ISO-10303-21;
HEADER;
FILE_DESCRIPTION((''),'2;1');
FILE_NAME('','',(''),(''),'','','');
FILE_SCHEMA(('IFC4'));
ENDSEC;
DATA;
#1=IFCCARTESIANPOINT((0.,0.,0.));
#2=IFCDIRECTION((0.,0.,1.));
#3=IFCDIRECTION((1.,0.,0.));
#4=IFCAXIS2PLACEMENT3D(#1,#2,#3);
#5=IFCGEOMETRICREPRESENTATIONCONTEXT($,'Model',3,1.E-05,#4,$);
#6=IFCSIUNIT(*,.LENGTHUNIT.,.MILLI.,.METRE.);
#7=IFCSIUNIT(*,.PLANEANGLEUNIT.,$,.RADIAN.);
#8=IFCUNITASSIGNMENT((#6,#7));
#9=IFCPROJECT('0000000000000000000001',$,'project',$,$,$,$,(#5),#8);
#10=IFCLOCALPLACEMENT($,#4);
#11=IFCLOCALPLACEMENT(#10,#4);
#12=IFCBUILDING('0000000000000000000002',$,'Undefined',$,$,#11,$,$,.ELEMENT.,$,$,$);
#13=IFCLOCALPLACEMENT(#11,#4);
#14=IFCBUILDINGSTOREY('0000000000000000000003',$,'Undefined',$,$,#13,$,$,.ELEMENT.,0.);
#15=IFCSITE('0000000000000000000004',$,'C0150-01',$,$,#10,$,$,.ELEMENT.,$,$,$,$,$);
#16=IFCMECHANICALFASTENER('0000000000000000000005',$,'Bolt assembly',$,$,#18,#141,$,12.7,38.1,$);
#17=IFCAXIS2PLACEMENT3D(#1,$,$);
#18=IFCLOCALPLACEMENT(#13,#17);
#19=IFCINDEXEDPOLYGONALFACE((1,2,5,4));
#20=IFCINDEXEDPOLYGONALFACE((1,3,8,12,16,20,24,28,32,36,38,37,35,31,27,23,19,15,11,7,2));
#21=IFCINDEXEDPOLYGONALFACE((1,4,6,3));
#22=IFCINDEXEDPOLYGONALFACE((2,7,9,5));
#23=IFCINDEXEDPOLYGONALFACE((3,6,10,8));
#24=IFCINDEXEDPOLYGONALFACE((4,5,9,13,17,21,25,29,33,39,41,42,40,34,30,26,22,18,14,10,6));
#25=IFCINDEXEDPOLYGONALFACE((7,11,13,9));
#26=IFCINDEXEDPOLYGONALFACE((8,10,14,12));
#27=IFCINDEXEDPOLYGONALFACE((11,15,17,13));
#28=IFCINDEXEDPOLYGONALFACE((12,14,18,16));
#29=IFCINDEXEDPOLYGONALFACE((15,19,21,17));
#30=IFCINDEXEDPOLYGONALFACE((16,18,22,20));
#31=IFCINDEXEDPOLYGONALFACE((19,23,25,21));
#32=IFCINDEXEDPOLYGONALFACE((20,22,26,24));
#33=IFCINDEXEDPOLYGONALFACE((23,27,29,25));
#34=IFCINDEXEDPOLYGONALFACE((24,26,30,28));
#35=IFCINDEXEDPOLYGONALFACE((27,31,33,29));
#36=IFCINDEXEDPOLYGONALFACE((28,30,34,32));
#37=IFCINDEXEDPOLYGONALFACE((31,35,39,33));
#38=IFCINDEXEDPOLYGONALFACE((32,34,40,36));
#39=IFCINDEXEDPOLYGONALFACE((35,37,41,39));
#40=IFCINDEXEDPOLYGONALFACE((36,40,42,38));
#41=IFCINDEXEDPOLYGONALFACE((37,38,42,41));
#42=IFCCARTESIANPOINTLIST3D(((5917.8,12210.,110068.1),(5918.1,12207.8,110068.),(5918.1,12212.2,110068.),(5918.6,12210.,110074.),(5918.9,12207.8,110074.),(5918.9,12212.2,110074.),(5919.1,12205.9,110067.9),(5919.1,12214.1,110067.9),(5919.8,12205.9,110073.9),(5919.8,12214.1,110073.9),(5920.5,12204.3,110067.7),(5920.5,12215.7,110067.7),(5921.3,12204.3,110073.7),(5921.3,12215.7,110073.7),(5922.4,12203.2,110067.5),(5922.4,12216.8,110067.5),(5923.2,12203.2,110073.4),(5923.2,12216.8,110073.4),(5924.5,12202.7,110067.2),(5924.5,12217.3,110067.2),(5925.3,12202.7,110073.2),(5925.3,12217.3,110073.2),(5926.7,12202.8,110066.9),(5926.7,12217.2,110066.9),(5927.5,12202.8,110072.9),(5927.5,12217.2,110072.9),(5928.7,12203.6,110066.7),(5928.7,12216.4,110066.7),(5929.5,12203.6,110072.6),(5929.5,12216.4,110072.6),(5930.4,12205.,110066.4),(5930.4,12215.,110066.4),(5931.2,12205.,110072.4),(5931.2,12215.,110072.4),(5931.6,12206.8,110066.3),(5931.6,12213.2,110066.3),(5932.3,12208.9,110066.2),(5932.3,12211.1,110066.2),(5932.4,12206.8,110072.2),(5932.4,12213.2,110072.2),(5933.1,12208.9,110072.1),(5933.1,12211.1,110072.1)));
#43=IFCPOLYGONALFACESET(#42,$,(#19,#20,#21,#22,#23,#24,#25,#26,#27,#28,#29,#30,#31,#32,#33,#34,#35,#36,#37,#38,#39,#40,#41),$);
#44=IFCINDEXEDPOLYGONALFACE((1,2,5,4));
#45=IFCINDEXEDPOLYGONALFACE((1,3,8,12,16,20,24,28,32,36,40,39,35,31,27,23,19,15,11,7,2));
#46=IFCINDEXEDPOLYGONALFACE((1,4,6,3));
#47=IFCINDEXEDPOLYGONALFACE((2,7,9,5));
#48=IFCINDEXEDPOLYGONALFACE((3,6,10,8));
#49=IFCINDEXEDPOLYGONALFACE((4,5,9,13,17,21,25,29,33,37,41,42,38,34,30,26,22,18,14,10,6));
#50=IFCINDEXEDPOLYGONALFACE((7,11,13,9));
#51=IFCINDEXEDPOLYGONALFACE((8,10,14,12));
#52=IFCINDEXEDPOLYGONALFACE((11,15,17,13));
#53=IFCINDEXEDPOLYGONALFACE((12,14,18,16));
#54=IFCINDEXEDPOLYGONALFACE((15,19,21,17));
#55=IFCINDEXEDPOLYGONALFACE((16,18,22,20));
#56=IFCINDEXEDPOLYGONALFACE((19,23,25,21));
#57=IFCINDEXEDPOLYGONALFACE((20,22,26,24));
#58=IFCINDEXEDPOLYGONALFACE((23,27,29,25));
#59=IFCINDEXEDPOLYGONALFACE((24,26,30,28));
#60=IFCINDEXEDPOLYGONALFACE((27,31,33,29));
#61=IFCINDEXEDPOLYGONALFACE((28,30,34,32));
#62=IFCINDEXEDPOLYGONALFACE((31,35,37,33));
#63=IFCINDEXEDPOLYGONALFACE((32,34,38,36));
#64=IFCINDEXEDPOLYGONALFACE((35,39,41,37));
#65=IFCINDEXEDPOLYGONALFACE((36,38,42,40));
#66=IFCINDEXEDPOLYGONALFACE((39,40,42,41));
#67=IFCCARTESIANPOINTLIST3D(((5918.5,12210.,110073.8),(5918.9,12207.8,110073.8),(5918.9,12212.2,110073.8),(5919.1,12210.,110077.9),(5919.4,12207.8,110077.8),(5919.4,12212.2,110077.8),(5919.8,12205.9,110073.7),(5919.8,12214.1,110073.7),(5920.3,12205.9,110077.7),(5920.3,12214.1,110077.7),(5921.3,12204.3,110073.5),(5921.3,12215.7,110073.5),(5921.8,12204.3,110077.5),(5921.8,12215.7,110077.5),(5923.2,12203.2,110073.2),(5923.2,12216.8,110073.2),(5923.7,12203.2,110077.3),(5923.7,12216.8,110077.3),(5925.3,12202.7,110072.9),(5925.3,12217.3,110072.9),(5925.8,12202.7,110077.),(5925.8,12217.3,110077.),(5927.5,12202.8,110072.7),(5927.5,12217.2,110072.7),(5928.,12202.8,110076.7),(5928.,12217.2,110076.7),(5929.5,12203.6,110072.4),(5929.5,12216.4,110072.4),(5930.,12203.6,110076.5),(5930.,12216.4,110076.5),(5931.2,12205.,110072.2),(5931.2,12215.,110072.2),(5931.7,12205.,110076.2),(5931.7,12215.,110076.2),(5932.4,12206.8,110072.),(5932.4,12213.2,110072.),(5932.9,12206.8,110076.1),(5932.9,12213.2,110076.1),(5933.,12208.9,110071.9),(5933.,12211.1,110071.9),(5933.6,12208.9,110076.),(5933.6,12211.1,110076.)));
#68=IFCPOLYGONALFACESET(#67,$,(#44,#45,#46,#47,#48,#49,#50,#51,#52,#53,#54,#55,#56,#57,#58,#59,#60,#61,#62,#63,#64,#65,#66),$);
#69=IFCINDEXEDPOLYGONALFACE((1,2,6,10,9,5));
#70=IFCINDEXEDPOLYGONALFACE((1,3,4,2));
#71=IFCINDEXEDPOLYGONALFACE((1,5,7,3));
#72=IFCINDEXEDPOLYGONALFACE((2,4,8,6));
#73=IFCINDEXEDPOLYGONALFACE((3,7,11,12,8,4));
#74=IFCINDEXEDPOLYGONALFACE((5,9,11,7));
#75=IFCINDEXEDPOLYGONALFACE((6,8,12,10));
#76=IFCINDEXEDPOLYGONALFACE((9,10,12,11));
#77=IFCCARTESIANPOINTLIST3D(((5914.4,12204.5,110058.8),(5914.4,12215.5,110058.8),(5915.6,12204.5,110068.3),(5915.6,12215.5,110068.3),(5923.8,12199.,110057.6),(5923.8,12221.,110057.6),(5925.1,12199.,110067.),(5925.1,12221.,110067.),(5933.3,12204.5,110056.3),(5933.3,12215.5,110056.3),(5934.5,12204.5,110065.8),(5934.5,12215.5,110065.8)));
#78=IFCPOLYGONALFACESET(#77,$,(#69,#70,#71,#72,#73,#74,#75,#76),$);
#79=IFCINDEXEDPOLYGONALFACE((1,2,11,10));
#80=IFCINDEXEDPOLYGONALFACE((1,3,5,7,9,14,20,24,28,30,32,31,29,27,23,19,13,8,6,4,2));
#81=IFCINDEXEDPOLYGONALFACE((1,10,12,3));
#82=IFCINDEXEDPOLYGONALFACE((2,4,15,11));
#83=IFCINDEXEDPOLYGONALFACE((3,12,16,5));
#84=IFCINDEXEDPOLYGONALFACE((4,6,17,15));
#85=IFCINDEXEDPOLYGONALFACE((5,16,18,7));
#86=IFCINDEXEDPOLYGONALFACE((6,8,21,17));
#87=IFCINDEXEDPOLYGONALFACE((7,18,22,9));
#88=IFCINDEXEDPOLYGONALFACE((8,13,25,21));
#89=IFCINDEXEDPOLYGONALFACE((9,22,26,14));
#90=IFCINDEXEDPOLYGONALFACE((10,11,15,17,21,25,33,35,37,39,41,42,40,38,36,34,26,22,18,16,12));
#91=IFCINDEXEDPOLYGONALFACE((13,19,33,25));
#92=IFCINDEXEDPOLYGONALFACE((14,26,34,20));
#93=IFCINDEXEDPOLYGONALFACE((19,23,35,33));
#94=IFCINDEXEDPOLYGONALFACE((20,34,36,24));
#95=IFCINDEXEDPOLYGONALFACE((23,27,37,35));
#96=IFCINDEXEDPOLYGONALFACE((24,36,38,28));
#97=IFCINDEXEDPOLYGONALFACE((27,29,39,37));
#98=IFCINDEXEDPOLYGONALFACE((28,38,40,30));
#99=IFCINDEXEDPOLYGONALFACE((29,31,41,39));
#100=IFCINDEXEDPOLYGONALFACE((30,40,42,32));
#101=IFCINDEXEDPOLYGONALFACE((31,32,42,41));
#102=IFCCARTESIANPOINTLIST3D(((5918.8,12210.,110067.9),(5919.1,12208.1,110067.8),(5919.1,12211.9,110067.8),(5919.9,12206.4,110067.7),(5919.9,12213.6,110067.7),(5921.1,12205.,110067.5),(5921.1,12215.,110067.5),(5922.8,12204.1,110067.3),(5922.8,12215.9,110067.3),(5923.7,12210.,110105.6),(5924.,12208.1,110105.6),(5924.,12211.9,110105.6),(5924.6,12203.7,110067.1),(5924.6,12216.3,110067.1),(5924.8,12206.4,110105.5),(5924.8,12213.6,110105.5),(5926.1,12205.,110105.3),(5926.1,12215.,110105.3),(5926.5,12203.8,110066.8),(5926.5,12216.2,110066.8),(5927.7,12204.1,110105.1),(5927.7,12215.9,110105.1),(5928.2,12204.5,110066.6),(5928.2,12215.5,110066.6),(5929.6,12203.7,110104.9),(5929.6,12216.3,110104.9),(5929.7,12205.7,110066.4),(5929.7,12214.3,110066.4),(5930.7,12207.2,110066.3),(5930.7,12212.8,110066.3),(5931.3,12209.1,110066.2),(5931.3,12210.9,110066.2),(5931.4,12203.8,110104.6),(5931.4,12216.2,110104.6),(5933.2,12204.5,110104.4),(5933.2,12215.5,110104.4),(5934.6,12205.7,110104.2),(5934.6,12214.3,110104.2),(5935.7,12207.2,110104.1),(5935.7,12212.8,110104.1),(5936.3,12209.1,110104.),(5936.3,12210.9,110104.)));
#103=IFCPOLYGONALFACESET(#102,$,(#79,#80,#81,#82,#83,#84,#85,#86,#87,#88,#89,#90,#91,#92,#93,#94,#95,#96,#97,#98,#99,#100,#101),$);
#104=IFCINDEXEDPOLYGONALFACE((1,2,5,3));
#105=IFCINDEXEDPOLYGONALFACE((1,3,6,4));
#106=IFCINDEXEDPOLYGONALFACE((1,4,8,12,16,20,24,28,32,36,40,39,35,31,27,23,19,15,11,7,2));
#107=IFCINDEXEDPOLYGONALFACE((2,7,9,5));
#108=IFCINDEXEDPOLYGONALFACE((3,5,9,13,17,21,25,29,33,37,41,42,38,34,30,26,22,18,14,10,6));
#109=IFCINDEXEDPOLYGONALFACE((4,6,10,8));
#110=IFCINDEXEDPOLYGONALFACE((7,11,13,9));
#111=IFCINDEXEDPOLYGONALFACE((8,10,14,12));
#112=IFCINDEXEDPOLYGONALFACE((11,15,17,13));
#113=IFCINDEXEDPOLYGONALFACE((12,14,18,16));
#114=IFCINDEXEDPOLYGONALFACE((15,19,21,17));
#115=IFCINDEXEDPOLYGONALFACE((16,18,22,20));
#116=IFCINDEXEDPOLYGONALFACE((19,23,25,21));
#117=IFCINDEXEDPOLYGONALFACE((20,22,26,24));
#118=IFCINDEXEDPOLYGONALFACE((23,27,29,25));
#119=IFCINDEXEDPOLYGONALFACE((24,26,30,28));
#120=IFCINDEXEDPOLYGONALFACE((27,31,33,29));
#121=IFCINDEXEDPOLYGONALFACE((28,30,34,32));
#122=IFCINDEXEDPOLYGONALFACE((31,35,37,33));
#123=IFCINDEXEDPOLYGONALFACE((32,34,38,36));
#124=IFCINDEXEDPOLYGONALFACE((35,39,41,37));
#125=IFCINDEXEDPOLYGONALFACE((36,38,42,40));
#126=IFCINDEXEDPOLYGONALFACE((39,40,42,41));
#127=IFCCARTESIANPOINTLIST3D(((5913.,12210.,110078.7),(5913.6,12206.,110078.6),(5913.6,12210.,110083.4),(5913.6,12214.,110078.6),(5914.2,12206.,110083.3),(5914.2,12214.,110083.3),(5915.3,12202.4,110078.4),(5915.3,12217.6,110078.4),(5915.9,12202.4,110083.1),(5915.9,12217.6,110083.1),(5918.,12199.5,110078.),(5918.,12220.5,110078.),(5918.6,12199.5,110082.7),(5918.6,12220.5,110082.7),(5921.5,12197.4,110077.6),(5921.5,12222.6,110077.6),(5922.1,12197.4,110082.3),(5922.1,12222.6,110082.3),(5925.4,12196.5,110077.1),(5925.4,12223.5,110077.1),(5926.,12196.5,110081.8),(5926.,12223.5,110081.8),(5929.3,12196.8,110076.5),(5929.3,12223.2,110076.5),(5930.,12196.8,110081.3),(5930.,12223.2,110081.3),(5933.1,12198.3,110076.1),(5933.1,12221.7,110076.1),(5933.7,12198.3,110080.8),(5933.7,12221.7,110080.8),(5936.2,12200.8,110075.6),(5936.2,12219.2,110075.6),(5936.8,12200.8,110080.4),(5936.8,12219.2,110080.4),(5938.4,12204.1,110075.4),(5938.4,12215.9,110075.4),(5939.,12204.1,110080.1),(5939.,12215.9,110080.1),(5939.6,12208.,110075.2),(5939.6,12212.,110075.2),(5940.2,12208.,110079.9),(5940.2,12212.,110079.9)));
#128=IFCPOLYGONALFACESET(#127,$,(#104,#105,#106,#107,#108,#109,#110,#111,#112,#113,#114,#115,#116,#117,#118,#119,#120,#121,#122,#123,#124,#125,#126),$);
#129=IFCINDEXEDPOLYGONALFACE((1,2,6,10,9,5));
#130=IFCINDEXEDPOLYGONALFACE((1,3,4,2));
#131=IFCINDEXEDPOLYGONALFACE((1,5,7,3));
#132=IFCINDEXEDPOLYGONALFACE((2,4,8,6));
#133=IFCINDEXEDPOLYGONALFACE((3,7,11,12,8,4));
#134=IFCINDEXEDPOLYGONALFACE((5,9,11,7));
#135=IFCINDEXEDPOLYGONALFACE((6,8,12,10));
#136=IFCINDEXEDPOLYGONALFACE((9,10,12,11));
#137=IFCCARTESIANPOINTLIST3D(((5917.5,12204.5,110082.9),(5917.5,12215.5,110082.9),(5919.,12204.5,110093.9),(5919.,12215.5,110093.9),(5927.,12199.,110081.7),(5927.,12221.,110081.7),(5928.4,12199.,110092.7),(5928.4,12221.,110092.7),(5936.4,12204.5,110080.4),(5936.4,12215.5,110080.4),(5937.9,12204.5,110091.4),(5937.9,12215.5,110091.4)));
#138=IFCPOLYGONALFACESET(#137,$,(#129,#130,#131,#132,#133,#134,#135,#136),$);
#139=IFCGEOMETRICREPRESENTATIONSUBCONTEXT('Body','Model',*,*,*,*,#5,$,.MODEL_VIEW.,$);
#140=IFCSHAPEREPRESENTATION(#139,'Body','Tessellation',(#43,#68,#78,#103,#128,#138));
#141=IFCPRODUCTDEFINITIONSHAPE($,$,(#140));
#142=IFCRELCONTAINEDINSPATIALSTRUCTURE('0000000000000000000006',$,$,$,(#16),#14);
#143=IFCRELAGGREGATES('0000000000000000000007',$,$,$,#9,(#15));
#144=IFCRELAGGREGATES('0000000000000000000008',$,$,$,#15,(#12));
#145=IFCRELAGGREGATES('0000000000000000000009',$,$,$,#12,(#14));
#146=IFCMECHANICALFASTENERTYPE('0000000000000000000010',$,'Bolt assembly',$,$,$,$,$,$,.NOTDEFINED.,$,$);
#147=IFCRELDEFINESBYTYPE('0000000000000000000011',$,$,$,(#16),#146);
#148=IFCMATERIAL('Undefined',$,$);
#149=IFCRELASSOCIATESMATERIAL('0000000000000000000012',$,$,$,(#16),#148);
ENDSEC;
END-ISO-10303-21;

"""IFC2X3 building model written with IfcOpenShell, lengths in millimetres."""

from ifc_helpers import new_model, si_unit, frame, origin_with_axes, origin_2d_with_axis, place, context, subcontext, project, spatial, polyline, circle, outline, extrude, source, transform, mapped, material, type_object, element, save


model = new_model("IFC2X3")

# Units and contexts
model_context = context("Model", 3, precision=1e-05, world=origin_with_axes())
body_context = subcontext(model_context, "Body", "Model", "MODEL_VIEW")
ifc_project = project(units=[si_unit("LENGTHUNIT", "METRE", prefix="MILLI"), si_unit("PLANEANGLEUNIT", "RADIAN")], contexts=[model_context])

# Site, building, storey
site_placement = place(None, origin_with_axes())
site = spatial("IfcSite", under=ifc_project, at=site_placement, Name="C0150-01", CompositionType="ELEMENT")
building_placement = place(site_placement, origin_with_axes())
building = spatial("IfcBuilding", under=site, at=building_placement, Name="Undefined", CompositionType="ELEMENT")
storey_placement = place(building_placement, origin_with_axes())
storey = spatial("IfcBuildingStorey", under=building, at=storey_placement, Name="Undefined", CompositionType="ELEMENT", Elevation=0.0)

# Mechanical fastener
ifc_material_1 = material(Name="Undefined")
mechanical_fastener_type = type_object("IfcMechanicalFastenerType", Name="Bolt assembly")
shared_shape_1 = source(origin_with_axes(), body_context, "Body", "SweptSolid", [
    extrude(circle(Radius=7.3, at=origin_2d_with_axis()), frame((0.0, -9.9, 0.0), z_axis=(0.0, 1.0, 0.0), x_axis=(1.0, 0.0, 0.0)), (0.0, 0.0, 1.0), 6.0),
    extrude(circle(Radius=7.3, at=origin_2d_with_axis()), frame((0.0, -4.1, 0.0), z_axis=(0.0, 1.0, 0.0), x_axis=(1.0, 0.0, 0.0)), (0.0, 0.0, 1.0), 4.1),
    extrude(outline(polyline([(9.5, -5.5), (9.5, 5.5), (0.0, 11.0), (-9.5, 5.5), (-9.5, -5.5), (0.0, -11.0), (9.5, -5.5)])), frame((0.0, -19.5, 0.0), z_axis=(0.0, 1.0, 0.0), x_axis=(1.0, 0.0, 0.0)), (0.0, 0.0, 1.0), 9.5),
    extrude(circle(Radius=6.3, at=origin_2d_with_axis()), frame((0.0, -10.0, 0.0), z_axis=(0.0, 1.0, 0.0), x_axis=(1.0, 0.0, 0.0)), (0.0, 0.0, 1.0), 38.1),
    extrude(circle(Radius=13.5, at=origin_2d_with_axis()), frame((0.0, 0.0, 0.0), z_axis=(0.0, 1.0, 0.0), x_axis=(1.0, 0.0, 0.0)), (0.0, 0.0, 1.0), 4.8),
    extrude(outline(polyline([(9.5, -5.5), (9.5, 5.5), (0.0, 11.0), (-9.5, 5.5), (-9.5, -5.5), (0.0, -11.0), (9.5, -5.5)])), frame((0.0, 4.8, 0.0), z_axis=(0.0, 1.0, 0.0), x_axis=(1.0, 0.0, 0.0)), (0.0, 0.0, 1.0), 11.1),
])
for number, where, z_axis, x_axis, name in (
    (1, (5926.4, 12210.0, 110076.9), (0.0, 1.0, 0.0), (-0.991507, 0.0, 0.130054), "Bolt assembly"),
):
    element("IfcMechanicalFastener", number, at=place(storey_placement, frame(where, z_axis=z_axis, x_axis=x_axis)), inside=storey, type_object=mechanical_fastener_type, material=ifc_material_1, Name=name, NominalDiameter=12.7, NominalLength=38.1, context=body_context, shape_type="MappedRepresentation", body=[
        mapped(shared_shape_1, transform((0.0, 0.0, 0.0))),
    ])

save(model, "model.ifc")
